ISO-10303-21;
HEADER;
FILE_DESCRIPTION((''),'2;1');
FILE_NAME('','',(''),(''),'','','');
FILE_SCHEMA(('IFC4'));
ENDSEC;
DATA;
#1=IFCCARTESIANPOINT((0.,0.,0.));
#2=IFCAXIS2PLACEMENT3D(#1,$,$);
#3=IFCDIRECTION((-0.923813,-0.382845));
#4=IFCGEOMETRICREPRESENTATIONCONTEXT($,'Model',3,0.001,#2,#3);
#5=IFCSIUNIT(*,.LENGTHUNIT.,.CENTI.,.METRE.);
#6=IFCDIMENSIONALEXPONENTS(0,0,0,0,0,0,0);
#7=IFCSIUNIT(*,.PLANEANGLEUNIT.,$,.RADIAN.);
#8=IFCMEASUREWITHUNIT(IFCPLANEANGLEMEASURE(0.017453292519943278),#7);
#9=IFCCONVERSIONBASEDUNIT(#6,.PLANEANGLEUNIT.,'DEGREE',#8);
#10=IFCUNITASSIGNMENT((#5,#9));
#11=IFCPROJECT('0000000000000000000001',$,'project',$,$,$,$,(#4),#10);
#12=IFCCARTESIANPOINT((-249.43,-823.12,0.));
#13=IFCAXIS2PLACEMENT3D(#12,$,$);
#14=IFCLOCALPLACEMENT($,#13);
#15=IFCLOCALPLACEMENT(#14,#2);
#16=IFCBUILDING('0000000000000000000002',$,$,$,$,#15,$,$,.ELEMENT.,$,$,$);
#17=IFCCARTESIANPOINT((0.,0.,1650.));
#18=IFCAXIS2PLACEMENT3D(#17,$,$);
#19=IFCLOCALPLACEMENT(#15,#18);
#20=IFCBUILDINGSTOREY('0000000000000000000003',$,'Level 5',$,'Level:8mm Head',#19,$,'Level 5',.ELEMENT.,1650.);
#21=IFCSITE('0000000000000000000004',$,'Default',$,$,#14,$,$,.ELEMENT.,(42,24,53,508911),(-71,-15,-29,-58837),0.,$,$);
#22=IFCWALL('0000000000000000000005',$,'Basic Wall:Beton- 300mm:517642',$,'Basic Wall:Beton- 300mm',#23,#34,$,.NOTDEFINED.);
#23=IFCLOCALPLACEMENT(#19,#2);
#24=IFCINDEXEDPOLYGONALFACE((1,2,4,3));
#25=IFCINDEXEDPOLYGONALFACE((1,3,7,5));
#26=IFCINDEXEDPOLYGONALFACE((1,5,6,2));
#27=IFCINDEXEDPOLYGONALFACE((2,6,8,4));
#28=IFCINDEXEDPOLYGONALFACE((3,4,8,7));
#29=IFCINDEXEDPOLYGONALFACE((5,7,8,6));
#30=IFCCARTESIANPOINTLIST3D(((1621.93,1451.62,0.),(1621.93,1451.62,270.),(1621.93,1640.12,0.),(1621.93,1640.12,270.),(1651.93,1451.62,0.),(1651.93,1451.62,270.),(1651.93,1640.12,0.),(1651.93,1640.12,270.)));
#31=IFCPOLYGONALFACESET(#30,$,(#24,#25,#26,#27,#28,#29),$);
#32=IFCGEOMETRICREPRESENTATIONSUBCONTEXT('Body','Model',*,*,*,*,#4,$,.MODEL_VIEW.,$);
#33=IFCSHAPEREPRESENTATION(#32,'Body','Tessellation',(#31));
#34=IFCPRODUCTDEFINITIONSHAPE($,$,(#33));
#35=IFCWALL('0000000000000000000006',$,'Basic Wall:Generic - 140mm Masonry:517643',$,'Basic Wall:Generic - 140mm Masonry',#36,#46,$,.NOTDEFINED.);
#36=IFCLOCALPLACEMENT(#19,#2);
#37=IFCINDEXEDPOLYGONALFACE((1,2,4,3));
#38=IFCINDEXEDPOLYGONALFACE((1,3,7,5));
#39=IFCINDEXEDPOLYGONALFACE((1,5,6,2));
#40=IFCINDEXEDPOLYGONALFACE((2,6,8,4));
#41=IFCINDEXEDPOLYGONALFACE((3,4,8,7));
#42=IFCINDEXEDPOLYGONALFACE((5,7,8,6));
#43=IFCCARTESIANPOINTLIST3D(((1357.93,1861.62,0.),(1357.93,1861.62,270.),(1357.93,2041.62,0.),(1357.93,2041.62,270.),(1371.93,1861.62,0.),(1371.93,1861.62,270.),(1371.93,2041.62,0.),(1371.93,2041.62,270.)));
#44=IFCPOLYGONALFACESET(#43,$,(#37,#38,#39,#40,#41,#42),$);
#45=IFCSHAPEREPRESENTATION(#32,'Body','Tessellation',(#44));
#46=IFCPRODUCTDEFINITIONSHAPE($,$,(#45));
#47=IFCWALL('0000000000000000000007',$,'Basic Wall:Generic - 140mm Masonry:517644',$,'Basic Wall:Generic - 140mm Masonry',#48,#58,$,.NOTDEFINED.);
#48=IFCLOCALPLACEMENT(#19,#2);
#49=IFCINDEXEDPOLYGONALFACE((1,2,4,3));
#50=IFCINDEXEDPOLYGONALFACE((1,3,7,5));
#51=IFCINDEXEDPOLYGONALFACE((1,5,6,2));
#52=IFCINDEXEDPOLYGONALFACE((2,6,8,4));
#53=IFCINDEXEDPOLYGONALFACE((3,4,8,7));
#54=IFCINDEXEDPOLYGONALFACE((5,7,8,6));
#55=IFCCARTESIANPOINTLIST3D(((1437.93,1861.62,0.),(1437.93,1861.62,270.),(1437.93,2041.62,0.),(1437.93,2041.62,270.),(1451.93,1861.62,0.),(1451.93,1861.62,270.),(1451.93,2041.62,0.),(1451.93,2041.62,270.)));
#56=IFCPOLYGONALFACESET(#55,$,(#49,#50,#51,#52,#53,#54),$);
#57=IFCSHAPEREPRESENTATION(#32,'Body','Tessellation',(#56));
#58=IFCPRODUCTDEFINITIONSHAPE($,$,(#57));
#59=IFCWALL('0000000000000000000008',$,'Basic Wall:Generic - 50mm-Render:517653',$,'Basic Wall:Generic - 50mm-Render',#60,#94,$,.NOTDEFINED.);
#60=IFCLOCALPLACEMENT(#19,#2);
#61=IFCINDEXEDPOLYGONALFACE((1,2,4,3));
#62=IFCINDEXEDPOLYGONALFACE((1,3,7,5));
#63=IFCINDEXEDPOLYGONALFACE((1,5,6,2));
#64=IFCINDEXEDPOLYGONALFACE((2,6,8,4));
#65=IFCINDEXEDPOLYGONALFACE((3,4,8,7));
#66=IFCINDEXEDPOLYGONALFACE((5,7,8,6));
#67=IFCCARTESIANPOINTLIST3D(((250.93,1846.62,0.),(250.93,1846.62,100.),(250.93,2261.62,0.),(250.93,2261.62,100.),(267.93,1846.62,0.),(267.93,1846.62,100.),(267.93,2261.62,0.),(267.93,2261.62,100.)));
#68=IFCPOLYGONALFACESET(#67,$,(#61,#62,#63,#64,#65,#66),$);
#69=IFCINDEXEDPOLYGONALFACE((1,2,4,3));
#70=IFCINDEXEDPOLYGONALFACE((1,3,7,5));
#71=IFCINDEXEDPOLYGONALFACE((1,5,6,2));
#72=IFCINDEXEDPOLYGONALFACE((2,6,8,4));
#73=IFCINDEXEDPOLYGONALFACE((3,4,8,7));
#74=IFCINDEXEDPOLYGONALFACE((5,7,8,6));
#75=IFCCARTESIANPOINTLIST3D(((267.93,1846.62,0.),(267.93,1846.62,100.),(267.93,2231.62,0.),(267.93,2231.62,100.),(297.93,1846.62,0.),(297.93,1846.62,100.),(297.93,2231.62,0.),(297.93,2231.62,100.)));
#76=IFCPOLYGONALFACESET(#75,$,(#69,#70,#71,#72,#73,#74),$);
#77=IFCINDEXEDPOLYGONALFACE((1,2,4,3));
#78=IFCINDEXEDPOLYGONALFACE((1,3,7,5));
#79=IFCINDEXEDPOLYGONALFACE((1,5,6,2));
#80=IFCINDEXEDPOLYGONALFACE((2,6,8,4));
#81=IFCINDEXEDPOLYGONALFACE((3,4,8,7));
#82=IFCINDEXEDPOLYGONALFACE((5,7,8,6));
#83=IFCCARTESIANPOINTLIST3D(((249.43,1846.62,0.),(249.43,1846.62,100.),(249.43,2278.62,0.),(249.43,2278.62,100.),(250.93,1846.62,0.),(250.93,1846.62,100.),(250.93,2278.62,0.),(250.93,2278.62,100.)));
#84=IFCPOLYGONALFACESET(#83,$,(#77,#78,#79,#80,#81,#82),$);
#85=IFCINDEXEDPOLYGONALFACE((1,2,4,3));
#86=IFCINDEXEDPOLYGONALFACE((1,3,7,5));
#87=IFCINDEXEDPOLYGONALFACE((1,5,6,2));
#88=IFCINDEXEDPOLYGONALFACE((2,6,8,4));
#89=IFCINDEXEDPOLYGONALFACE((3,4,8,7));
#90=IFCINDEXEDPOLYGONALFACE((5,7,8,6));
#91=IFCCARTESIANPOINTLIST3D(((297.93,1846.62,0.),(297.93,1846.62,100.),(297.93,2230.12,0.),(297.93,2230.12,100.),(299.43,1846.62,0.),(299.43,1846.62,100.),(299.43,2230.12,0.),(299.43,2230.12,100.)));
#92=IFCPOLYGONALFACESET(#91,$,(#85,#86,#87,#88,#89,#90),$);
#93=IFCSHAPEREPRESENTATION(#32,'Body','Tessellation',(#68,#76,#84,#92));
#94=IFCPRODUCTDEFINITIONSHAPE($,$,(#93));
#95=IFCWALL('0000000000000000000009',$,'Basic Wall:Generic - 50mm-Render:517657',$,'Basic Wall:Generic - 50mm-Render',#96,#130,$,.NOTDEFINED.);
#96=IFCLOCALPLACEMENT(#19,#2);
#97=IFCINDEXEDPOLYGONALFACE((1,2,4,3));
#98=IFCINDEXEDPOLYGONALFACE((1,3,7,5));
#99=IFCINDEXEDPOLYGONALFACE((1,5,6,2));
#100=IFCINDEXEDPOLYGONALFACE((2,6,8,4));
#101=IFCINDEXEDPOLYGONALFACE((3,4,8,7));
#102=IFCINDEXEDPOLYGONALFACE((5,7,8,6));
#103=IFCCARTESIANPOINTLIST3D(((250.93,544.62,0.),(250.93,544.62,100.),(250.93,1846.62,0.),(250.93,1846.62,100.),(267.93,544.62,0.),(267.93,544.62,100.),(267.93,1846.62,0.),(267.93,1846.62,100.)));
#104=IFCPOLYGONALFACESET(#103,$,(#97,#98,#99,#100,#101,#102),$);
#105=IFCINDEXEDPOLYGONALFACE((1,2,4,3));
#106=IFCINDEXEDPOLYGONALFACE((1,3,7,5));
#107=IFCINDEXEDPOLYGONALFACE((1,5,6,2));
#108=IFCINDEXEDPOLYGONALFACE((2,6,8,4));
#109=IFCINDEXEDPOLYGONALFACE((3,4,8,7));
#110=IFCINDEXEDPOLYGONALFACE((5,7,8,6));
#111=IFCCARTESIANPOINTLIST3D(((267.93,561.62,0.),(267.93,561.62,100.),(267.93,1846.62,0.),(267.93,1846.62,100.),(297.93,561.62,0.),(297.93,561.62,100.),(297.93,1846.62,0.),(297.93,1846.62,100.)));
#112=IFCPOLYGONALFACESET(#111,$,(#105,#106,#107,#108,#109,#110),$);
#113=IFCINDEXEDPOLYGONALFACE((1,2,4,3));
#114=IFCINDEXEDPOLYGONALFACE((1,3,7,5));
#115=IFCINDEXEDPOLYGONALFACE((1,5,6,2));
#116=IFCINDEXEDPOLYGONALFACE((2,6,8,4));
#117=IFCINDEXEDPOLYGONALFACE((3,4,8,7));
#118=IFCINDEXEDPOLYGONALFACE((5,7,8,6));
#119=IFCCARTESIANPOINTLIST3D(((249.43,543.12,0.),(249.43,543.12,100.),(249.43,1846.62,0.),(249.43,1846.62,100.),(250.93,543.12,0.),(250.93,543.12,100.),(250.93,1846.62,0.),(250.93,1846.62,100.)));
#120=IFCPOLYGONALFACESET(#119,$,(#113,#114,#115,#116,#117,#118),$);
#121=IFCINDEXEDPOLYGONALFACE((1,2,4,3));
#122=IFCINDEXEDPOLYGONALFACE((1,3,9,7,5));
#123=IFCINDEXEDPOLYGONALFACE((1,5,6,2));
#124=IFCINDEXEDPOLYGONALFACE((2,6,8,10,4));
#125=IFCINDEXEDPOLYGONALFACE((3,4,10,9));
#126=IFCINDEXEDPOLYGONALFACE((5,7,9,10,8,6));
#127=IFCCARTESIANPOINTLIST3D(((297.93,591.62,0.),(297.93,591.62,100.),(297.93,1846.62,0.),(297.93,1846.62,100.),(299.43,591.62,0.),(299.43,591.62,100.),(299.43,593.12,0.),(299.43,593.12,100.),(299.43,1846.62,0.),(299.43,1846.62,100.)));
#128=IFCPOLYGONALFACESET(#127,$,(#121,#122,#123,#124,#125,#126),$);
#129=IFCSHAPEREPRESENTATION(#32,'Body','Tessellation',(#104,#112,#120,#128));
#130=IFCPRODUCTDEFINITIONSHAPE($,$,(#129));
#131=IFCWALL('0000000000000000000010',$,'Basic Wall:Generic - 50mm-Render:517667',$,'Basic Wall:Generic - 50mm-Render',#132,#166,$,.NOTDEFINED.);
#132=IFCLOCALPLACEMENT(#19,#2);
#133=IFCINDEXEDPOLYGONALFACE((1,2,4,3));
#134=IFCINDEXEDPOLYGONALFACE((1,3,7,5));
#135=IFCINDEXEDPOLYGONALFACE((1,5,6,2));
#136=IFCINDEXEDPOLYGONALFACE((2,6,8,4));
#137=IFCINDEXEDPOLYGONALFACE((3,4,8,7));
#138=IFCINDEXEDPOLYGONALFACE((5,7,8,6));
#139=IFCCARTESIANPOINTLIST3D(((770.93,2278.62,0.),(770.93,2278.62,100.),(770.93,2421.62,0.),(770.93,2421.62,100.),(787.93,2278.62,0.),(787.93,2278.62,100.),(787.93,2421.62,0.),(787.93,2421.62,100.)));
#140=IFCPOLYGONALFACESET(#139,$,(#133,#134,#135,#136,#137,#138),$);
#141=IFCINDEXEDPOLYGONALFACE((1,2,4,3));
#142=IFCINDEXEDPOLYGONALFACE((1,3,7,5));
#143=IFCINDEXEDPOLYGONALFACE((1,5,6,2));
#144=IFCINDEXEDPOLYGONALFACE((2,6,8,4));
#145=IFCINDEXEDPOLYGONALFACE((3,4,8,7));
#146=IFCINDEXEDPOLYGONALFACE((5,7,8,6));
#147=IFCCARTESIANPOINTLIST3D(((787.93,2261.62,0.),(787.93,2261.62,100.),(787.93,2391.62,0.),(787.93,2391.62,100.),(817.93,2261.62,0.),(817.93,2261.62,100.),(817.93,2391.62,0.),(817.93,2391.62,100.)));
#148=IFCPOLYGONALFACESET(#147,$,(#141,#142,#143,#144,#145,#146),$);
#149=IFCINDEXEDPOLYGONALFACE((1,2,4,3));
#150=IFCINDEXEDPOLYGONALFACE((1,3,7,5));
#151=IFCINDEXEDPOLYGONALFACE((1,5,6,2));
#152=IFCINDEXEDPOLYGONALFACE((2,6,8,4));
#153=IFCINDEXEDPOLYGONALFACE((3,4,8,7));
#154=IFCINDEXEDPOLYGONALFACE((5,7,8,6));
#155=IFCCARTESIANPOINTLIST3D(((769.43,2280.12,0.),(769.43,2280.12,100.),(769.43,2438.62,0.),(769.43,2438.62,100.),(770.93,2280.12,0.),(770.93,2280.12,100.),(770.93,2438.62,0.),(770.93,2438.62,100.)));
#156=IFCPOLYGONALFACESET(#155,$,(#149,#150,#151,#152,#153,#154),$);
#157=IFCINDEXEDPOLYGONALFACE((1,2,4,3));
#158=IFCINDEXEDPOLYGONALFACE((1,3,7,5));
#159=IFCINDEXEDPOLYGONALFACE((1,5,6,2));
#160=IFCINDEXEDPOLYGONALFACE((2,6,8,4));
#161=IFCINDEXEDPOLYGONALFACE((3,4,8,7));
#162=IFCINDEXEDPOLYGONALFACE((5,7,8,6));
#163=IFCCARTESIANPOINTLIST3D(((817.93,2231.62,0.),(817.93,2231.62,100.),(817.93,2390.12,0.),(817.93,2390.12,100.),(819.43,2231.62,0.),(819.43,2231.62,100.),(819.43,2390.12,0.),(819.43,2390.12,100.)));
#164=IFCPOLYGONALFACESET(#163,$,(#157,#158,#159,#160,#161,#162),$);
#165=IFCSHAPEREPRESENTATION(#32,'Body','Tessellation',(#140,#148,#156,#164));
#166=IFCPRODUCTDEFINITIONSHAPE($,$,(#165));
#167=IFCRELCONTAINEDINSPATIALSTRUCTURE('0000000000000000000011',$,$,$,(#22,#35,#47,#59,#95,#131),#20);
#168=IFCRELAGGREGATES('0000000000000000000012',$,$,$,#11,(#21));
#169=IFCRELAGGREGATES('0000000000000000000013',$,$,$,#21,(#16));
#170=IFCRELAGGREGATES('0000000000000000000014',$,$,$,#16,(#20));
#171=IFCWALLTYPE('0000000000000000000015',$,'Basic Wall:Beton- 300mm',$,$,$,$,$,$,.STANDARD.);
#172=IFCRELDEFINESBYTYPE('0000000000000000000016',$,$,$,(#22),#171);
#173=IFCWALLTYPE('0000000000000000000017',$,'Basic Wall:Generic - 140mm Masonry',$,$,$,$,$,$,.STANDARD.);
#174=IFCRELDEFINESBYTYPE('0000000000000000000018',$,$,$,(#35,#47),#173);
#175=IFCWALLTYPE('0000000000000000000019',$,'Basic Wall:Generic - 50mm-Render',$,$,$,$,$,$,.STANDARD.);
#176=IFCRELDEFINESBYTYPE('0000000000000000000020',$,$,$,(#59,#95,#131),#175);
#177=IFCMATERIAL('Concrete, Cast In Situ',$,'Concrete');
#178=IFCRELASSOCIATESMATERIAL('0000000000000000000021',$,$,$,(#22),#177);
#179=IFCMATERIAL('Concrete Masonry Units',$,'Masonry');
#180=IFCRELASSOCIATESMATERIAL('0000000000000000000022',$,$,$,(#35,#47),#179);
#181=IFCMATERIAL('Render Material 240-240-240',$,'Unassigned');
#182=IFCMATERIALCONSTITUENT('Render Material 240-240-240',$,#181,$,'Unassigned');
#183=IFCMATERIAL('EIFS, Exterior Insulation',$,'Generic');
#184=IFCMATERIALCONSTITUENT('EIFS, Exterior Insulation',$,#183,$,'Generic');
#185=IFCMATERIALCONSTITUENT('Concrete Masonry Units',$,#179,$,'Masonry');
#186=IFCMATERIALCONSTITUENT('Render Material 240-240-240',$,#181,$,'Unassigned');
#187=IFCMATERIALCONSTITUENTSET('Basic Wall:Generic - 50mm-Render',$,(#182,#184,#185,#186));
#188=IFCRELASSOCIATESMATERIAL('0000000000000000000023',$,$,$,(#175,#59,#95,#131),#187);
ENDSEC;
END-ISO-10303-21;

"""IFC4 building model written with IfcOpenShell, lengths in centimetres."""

from ifc_helpers import new_model, entity, si_unit, converted_unit, direction, frame, origin, place, context, subcontext, project, spatial, indexed_curve, outline, extrude, material, constituent, constituent_set, type_object, element, save


model = new_model("IFC4")

# Units and contexts
model_context = context("Model", 3, precision=0.001, world=origin(), true_north=direction((-0.923813, -0.382845)))
body_context = subcontext(model_context, "Body", "Model", "MODEL_VIEW")
ifc_project = project(units=[si_unit("LENGTHUNIT", "METRE", prefix="CENTI"), converted_unit("PLANEANGLEUNIT", "DEGREE", entity("IfcPlaneAngleMeasure", 0.017453292519943278), si_unit("PLANEANGLEUNIT", "RADIAN"), dimensions=[0, 0, 0, 0, 0, 0, 0])], contexts=[model_context])

# Site, building, storey
site_placement = place(None, frame((-249.43, -823.12, 0.0)))
site = spatial("IfcSite", under=ifc_project, at=site_placement, Name="Default", CompositionType="ELEMENT", RefLatitude=(42, 24, 53, 508911), RefLongitude=(-71, -15, -29, -58837), RefElevation=0.0)
building_placement = place(site_placement, origin())
building = spatial("IfcBuilding", under=site, at=building_placement, CompositionType="ELEMENT")
storey_placement = place(building_placement, frame((0.0, 0.0, 1650.0)))
storey = spatial("IfcBuildingStorey", under=building, at=storey_placement, Name="Level 5", ObjectType="Level:8mm Head", LongName="Level 5", CompositionType="ELEMENT", Elevation=1650.0)

# Walls
ifc_material_1 = material(Name="Concrete, Cast In Situ", Category="Concrete")
wall_type_1 = type_object("IfcWallType", Name="Basic Wall:Beton- 300mm", PredefinedType="STANDARD")
wall_1_placement = place(storey_placement, frame((1636.93, 1451.62, 0.0), z_axis=(0.0, 0.0, 1.0), x_axis=(0.0, 1.0, 0.0)))
element("IfcWall", 1, at=wall_1_placement, inside=storey, type_object=wall_type_1, material=ifc_material_1, Name="Basic Wall:Beton- 300mm:517642", ObjectType="Basic Wall:Beton- 300mm", PredefinedType="NOTDEFINED", context=body_context, shape_type="SweptSolid", body=[
    extrude(outline(indexed_curve([(188.5, 15.0), (0.0, 15.0), (0.0, -15.0), (188.5, -15.0), (188.5, 15.0)], self_intersect=False)), origin(), (0.0, 0.0, 1.0), 270.0),
])
ifc_material_2 = material(Name="Concrete Masonry Units", Category="Masonry")
wall_type_2 = type_object("IfcWallType", Name="Basic Wall:Generic - 140mm Masonry", PredefinedType="STANDARD")
wall_2_placement = place(storey_placement, frame((1364.93, 2041.62, 0.0), z_axis=(0.0, 0.0, 1.0), x_axis=(0.0, -1.0, 0.0)))
element("IfcWall", 2, at=wall_2_placement, inside=storey, type_object=wall_type_2, material=ifc_material_2, Name="Basic Wall:Generic - 140mm Masonry:517643", ObjectType="Basic Wall:Generic - 140mm Masonry", PredefinedType="NOTDEFINED", context=body_context, shape_type="SweptSolid", body=[
    extrude(outline(indexed_curve([(180.0, 7.0), (0.0, 7.0), (0.0, -7.0), (180.0, -7.0), (180.0, 7.0)], self_intersect=False)), origin(), (0.0, 0.0, 1.0), 270.0),
])
wall_3_placement = place(storey_placement, frame((1444.93, 2041.62, 0.0), z_axis=(0.0, 0.0, 1.0), x_axis=(0.0, -1.0, 0.0)))
element("IfcWall", 3, at=wall_3_placement, inside=storey, type_object=wall_type_2, material=ifc_material_2, Name="Basic Wall:Generic - 140mm Masonry:517644", ObjectType="Basic Wall:Generic - 140mm Masonry", PredefinedType="NOTDEFINED", context=body_context, shape_type="SweptSolid", body=[
    extrude(outline(indexed_curve([(180.0, 7.0), (0.0, 7.0), (0.0, -7.0), (180.0, -7.0), (180.0, 7.0)], self_intersect=False)), origin(), (0.0, 0.0, 1.0), 270.0),
])
ifc_material_3 = material(Name="Render Material 240-240-240", Category="Unassigned")
ifc_constituent_1 = constituent(ifc_material_3, Name="Render Material 240-240-240", Category="Unassigned")
ifc_material_4 = material(Name="EIFS, Exterior Insulation", Category="Generic")
ifc_constituent_2 = constituent(ifc_material_4, Name="EIFS, Exterior Insulation", Category="Generic")
ifc_constituent_3 = constituent(ifc_material_2, Name="Concrete Masonry Units", Category="Masonry")
ifc_constituent_4 = constituent(ifc_material_3, Name="Render Material 240-240-240", Category="Unassigned")
ifc_constituent_set_1 = constituent_set(constituents=[ifc_constituent_1, ifc_constituent_2, ifc_constituent_3, ifc_constituent_4], Name="Basic Wall:Generic - 50mm-Render")
wall_type_3 = type_object("IfcWallType", Name="Basic Wall:Generic - 50mm-Render", PredefinedType="STANDARD", material=ifc_constituent_set_1)
wall_4_placement = place(storey_placement, frame((274.43, 2230.12, 0.0), z_axis=(0.0, 0.0, 1.0), x_axis=(0.0, -1.0, 0.0)))
element("IfcWall", 4, at=wall_4_placement, inside=storey, type_object=wall_type_3, material=ifc_constituent_set_1, Name="Basic Wall:Generic - 50mm-Render:517653", ObjectType="Basic Wall:Generic - 50mm-Render", PredefinedType="NOTDEFINED", context=body_context, shape_type="SweptSolid", body=[
    extrude(outline(indexed_curve([(-207.5, -8.5), (207.5, -8.5), (207.5, 8.5), (-207.5, 8.5), (-207.5, -8.5)], self_intersect=False)), frame((176.0, -15.0, 0.0)), (0.0, 0.0, 1.0), 100.0),
    extrude(outline(indexed_curve([(-192.5, -15.0), (192.5, -15.0), (192.5, 15.0), (-192.5, 15.0), (-192.5, -15.0)], self_intersect=False)), frame((191.0, 8.5, 0.0)), (0.0, 0.0, 1.0), 100.0),
    extrude(outline(indexed_curve([(-0.75, -216.0), (0.75, -216.0), (0.75, 216.0), (-0.75, 216.0), (-0.75, -216.0)], self_intersect=False)), frame((167.5, -24.25, 0.0), z_axis=(0.0, 0.0, 1.0), x_axis=(0.0, 1.0, 0.0)), (0.0, 0.0, 1.0), 100.0),
    extrude(outline(indexed_curve([(-0.75, -191.75), (0.75, -191.75), (0.75, 191.75), (-0.75, 191.75), (-0.75, -191.75)], self_intersect=False)), frame((191.75, 24.25, 0.0), z_axis=(0.0, 0.0, 1.0), x_axis=(0.0, -1.0, 0.0)), (0.0, 0.0, 1.0), 100.0),
])
wall_5_placement = place(storey_placement, frame((274.43, 1846.62, 0.0), z_axis=(0.0, 0.0, 1.0), x_axis=(0.0, -1.0, 0.0)))
element("IfcWall", 5, at=wall_5_placement, inside=storey, type_object=wall_type_3, material=ifc_constituent_set_1, Name="Basic Wall:Generic - 50mm-Render:517657", ObjectType="Basic Wall:Generic - 50mm-Render", PredefinedType="NOTDEFINED", context=body_context, shape_type="SweptSolid", body=[
    extrude(outline(indexed_curve([(-651.0, -8.5), (651.0, -8.5), (651.0, 8.5), (-651.0, 8.5), (-651.0, -8.5)], self_intersect=False)), frame((651.0, -15.0, 0.0)), (0.0, 0.0, 1.0), 100.0),
    extrude(outline(indexed_curve([(-642.5, -15.0), (642.5, -15.0), (642.5, 15.0), (-642.5, 15.0), (-642.5, -15.0)], self_intersect=False)), frame((642.5, 8.5, 0.0)), (0.0, 0.0, 1.0), 100.0),
    extrude(outline(indexed_curve([(-0.75, -651.75), (0.75, -651.75), (0.75, 651.75), (-0.75, 651.75), (-0.75, -651.75)], self_intersect=False)), frame((651.75, -24.25, 0.0), z_axis=(0.0, 0.0, 1.0), x_axis=(0.0, 1.0, 0.0)), (0.0, 0.0, 1.0), 100.0),
    extrude(outline(indexed_curve([(-500.8, -0.6), (752.7, -0.6), (752.7, 0.9), (-502.3, 0.9), (-502.3, -0.6), (-500.8, -0.6)], self_intersect=False)), frame((752.7, 24.4, 0.0), z_axis=(0.0, 0.0, 1.0), x_axis=(-1.0, 0.0, 0.0)), (0.0, 0.0, 1.0), 100.0),
])
wall_6_placement = place(storey_placement, frame((794.43, 2280.12, 0.0), z_axis=(0.0, 0.0, 1.0), x_axis=(0.0, 1.0, 0.0)))
element("IfcWall", 6, at=wall_6_placement, inside=storey, type_object=wall_type_3, material=ifc_constituent_set_1, Name="Basic Wall:Generic - 50mm-Render:517667", ObjectType="Basic Wall:Generic - 50mm-Render", PredefinedType="NOTDEFINED", context=body_context, shape_type="SweptSolid", body=[
    extrude(outline(indexed_curve([(-71.5, -8.5), (71.5, -8.5), (71.5, 8.5), (-71.5, 8.5), (-71.5, -8.5)], self_intersect=False)), frame((70.0, 15.0, 0.0)), (0.0, 0.0, 1.0), 100.0),
    extrude(outline(indexed_curve([(-65.0, -15.0), (65.0, -15.0), (65.0, 15.0), (-65.0, 15.0), (-65.0, -15.0)], self_intersect=False)), frame((46.5, -8.5, 0.0)), (0.0, 0.0, 1.0), 100.0),
    extrude(outline(indexed_curve([(-0.75, -79.25), (0.75, -79.25), (0.75, 79.25), (-0.75, 79.25), (-0.75, -79.25)], self_intersect=False)), frame((79.25, 24.25, 0.0), z_axis=(0.0, 0.0, 1.0), x_axis=(0.0, -1.0, 0.0)), (0.0, 0.0, 1.0), 100.0),
    extrude(outline(indexed_curve([(-0.75, -79.25), (0.75, -79.25), (0.75, 79.25), (-0.75, 79.25), (-0.75, -79.25)], self_intersect=False)), frame((30.75, -24.25, 0.0), z_axis=(0.0, 0.0, 1.0), x_axis=(0.0, 1.0, 0.0)), (0.0, 0.0, 1.0), 100.0),
])

save(model, "model.ifc")
